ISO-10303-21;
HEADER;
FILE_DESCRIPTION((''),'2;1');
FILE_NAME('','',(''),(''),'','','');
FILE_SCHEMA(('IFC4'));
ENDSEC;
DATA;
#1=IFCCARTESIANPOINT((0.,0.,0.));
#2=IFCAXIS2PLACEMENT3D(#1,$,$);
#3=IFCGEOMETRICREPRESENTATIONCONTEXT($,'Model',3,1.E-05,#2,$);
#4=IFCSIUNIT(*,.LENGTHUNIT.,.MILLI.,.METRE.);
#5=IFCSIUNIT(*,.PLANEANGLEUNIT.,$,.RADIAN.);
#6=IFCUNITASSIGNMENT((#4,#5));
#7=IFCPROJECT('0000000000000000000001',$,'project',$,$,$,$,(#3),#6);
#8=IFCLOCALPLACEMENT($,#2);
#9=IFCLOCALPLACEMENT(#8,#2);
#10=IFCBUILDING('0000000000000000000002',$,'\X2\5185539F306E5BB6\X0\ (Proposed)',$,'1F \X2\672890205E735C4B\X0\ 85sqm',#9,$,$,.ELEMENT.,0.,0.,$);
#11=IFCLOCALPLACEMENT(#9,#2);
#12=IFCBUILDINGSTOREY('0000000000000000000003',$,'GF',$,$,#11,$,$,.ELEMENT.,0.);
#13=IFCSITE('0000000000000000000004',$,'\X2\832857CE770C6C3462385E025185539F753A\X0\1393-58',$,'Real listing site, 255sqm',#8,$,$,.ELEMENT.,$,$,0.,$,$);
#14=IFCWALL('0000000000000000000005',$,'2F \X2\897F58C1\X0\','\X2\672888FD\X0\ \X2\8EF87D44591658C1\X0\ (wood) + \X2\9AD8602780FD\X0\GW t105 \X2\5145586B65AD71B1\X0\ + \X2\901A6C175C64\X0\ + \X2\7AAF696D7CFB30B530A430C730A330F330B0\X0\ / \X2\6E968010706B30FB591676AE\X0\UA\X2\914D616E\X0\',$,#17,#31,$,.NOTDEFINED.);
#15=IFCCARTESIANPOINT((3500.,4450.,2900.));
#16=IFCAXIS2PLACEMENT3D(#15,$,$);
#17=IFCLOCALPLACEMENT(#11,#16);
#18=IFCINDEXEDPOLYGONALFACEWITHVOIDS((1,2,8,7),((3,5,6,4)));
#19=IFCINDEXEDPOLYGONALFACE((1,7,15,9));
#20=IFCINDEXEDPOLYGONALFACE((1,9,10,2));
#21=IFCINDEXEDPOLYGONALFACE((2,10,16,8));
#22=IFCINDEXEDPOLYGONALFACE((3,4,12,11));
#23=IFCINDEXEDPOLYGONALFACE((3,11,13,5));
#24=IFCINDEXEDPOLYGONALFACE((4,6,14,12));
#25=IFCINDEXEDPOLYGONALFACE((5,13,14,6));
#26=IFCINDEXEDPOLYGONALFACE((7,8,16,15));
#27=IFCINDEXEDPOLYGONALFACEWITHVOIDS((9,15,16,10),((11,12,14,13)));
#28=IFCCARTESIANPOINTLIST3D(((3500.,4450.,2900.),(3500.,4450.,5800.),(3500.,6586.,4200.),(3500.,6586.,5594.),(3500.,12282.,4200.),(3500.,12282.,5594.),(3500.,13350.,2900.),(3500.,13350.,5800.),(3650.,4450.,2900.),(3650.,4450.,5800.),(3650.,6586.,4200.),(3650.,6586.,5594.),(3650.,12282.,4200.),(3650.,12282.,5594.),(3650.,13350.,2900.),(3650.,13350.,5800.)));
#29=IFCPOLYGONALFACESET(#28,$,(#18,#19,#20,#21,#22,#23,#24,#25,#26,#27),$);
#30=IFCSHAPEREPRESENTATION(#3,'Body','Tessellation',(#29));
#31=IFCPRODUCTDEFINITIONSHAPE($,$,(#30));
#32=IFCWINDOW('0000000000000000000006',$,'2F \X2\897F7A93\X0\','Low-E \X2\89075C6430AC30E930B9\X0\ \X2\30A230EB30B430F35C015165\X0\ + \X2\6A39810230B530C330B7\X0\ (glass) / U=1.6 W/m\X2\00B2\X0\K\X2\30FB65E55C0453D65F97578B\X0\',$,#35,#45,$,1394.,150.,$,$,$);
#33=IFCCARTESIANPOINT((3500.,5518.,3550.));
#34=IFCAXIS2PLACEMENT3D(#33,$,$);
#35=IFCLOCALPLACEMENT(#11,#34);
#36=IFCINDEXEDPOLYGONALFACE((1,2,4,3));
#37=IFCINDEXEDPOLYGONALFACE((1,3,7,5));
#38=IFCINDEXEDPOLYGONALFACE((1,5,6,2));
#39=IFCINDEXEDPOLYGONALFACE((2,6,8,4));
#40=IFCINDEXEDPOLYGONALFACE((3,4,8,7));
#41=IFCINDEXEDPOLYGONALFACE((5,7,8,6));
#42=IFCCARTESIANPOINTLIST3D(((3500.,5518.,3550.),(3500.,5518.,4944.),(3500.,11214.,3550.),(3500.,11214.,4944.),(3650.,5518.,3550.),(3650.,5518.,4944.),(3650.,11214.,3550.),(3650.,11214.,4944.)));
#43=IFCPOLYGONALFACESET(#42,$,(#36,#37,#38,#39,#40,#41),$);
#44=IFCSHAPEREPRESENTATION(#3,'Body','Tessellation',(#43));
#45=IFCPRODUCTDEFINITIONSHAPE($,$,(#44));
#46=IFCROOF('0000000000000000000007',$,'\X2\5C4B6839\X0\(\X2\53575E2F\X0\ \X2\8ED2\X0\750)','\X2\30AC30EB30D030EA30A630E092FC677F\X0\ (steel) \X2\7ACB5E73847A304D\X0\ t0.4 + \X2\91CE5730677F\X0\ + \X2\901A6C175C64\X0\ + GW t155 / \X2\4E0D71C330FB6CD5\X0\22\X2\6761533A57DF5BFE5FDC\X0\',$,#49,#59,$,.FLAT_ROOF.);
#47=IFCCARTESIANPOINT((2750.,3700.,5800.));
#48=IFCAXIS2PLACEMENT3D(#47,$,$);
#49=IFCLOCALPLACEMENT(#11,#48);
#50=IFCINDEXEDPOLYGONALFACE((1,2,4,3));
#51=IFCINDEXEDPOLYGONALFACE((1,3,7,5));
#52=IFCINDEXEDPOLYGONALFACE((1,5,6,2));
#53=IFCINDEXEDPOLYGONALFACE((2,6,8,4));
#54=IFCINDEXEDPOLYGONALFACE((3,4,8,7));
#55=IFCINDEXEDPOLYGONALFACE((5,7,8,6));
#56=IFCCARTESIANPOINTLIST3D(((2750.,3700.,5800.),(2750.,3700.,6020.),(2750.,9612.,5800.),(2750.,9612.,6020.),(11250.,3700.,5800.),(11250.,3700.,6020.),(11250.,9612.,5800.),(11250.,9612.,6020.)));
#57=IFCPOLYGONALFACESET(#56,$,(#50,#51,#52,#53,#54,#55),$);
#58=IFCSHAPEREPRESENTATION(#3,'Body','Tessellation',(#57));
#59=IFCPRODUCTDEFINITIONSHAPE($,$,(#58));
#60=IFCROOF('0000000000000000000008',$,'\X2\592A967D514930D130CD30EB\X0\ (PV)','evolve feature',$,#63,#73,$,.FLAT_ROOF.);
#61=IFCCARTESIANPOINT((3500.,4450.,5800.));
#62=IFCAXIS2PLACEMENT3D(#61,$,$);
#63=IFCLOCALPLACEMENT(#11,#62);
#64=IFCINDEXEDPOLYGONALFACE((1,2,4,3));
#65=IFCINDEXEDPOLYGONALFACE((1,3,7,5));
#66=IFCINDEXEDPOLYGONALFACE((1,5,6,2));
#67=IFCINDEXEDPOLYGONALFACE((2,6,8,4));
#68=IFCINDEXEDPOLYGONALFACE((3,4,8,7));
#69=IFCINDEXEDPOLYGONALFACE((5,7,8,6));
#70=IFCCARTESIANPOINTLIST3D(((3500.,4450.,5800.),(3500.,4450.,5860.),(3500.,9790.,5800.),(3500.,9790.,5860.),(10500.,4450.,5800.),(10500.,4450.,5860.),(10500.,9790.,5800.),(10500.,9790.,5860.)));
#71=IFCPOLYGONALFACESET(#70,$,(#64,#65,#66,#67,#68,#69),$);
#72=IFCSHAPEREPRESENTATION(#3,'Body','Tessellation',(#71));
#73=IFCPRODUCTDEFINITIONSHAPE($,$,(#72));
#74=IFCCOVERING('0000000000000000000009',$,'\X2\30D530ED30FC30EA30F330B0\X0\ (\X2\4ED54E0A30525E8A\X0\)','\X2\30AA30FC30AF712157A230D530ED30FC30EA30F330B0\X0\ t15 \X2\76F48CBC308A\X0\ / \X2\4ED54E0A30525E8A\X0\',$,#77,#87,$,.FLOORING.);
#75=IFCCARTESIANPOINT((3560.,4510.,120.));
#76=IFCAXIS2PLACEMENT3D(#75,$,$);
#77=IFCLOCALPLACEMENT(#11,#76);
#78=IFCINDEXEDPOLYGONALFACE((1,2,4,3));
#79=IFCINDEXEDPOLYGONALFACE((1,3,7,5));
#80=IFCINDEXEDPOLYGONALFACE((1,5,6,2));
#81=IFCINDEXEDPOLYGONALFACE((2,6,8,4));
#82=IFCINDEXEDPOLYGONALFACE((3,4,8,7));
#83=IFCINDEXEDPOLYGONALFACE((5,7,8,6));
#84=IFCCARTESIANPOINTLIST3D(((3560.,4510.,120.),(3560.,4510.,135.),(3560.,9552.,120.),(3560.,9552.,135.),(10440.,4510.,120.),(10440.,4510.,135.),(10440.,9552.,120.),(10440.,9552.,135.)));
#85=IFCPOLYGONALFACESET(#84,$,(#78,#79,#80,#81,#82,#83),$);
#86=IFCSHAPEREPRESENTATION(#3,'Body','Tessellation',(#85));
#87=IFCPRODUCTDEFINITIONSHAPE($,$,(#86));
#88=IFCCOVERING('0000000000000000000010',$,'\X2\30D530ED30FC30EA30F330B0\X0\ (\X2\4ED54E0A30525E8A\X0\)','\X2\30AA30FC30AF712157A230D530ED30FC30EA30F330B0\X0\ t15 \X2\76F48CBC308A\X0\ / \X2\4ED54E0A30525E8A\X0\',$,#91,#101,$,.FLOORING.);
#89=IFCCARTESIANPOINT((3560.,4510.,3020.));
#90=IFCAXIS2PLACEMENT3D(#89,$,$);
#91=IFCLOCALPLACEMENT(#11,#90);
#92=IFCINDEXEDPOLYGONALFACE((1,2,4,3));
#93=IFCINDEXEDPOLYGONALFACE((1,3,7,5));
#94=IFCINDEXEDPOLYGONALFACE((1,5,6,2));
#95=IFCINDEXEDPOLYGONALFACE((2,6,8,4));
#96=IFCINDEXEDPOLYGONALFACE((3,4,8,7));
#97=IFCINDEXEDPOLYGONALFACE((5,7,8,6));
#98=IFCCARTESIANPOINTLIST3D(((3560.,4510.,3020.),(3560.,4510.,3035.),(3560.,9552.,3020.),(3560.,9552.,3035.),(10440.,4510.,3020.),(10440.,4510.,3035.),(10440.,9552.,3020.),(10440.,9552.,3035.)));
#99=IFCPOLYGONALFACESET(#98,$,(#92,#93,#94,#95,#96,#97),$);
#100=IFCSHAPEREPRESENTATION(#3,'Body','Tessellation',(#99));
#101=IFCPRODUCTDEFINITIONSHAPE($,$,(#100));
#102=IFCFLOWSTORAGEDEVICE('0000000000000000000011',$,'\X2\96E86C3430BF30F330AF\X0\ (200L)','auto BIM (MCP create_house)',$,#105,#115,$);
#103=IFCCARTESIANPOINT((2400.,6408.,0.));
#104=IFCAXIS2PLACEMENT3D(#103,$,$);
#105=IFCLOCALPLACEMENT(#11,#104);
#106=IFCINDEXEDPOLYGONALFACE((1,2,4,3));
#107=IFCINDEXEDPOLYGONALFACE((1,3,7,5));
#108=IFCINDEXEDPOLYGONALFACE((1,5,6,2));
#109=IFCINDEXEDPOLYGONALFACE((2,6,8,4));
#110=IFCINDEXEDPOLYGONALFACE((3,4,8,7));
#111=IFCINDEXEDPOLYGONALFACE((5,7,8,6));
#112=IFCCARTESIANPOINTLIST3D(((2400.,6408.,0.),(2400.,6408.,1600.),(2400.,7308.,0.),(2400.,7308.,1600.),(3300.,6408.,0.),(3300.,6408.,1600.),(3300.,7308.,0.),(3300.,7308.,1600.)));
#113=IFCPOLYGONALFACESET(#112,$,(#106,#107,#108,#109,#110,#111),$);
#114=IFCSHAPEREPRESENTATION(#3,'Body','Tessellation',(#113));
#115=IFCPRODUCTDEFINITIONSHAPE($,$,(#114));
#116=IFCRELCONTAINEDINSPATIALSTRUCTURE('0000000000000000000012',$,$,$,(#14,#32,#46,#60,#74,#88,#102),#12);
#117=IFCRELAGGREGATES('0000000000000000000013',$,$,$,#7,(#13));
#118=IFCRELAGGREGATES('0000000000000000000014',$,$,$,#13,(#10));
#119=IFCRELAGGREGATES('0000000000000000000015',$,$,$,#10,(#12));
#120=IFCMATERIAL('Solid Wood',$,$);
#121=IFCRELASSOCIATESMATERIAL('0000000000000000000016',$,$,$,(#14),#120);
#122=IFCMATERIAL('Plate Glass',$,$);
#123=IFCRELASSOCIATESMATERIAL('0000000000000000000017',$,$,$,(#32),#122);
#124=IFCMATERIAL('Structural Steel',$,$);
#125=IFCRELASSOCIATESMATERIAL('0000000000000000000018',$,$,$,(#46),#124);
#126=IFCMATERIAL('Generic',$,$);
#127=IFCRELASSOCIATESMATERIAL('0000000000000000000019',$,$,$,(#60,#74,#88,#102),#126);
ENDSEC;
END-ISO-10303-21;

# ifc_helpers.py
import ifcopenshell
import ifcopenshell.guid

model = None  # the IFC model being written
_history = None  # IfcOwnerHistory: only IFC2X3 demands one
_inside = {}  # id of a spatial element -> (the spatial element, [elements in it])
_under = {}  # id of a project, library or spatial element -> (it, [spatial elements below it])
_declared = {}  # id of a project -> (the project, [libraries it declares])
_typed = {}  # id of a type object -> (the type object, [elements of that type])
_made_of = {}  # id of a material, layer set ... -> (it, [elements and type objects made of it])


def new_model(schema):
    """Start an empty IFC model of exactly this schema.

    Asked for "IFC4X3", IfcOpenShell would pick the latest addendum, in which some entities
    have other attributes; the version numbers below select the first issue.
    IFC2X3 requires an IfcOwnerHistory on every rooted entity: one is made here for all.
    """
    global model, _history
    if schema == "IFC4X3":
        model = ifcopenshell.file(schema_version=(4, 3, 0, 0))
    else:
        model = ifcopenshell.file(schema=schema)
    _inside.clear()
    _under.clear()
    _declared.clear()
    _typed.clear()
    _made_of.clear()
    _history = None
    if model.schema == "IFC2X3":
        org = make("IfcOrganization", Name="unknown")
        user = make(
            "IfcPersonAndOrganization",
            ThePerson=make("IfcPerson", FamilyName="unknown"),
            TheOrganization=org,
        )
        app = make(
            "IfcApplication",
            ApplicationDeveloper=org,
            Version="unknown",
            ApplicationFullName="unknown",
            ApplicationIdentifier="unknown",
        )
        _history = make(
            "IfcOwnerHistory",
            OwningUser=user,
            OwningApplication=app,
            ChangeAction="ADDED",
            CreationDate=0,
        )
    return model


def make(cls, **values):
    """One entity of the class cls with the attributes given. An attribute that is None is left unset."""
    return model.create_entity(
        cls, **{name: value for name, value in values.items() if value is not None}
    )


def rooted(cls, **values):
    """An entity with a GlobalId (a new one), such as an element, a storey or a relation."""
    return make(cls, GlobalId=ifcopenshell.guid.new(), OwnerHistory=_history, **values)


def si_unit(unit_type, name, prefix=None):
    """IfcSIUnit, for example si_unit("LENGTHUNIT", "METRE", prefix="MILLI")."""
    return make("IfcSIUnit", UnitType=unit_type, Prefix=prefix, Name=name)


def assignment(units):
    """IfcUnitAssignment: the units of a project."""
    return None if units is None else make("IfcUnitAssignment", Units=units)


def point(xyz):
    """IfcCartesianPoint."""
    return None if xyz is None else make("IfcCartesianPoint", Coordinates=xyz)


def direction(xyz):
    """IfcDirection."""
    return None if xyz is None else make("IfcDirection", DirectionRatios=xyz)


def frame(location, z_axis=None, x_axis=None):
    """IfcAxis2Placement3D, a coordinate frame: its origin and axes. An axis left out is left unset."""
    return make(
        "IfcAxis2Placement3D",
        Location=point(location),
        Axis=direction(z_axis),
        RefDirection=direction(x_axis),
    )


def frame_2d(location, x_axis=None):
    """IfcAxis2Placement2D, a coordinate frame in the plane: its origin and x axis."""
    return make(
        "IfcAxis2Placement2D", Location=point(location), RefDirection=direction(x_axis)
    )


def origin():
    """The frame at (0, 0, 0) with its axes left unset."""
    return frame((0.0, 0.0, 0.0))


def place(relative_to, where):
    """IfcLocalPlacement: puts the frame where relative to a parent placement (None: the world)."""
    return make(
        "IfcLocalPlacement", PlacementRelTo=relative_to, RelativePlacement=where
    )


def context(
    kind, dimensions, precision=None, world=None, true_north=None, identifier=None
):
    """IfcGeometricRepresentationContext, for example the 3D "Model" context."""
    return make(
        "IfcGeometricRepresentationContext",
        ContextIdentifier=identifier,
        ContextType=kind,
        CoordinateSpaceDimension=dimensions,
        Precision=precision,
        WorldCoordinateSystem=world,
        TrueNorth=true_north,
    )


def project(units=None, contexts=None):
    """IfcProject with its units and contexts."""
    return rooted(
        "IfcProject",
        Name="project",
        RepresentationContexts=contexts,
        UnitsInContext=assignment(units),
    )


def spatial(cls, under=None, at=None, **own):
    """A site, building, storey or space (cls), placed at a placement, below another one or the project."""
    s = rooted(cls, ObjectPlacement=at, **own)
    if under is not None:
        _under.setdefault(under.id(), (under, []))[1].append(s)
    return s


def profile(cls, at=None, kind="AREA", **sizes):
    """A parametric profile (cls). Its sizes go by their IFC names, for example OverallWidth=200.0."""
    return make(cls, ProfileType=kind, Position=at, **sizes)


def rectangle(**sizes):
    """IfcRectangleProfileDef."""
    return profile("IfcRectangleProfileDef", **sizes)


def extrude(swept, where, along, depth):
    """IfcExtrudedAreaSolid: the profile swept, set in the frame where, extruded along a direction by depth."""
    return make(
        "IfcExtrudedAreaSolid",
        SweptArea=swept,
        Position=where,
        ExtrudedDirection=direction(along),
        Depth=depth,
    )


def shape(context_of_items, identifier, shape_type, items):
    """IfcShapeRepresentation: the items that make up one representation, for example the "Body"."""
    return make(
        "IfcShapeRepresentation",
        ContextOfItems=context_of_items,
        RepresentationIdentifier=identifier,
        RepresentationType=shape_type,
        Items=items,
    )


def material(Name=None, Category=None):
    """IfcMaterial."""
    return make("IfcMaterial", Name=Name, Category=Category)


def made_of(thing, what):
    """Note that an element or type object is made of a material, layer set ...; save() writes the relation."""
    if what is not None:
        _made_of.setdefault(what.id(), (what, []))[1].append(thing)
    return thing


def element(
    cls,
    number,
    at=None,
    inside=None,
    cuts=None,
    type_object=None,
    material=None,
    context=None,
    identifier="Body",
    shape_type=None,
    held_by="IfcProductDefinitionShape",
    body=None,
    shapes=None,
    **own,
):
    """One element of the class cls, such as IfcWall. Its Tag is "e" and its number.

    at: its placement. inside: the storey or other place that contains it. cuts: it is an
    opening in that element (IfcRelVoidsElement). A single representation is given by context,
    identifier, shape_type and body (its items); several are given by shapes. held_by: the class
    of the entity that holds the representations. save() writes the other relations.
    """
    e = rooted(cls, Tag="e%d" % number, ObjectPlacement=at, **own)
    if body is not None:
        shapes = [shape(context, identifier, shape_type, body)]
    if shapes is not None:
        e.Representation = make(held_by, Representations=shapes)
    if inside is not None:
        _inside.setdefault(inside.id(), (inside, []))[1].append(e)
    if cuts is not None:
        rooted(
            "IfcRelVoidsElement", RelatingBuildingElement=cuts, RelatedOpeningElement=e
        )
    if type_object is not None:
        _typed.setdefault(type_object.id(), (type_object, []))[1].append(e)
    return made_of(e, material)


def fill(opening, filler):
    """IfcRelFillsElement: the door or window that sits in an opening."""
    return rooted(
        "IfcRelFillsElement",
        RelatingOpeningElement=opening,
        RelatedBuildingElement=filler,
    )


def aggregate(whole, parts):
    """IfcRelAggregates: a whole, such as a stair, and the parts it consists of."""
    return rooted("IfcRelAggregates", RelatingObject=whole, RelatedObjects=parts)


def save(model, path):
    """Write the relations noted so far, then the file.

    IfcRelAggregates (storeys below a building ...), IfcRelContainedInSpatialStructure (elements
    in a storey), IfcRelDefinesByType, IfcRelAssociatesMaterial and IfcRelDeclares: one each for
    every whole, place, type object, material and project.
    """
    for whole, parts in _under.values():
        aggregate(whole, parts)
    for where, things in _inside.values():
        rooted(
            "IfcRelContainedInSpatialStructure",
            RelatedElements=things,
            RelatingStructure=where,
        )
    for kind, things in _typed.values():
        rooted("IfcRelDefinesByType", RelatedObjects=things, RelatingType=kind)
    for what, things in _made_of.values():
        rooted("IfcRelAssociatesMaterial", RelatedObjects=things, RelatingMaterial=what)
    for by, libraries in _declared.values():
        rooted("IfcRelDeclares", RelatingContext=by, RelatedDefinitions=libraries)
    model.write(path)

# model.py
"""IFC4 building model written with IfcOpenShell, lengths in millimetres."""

from ifc_helpers import new_model, si_unit, frame, frame_2d, origin, place, context, project, spatial, rectangle, extrude, material, element, fill, save


model = new_model("IFC4")

# Units and contexts
model_context = context("Model", 3, precision=1e-05, world=origin())
ifc_project = project(units=[si_unit("LENGTHUNIT", "METRE", prefix="MILLI"), si_unit("PLANEANGLEUNIT", "RADIAN")], contexts=[model_context])

# Site, building, storey
site_placement = place(None, origin())
site = spatial("IfcSite", under=ifc_project, at=site_placement, Name="茨城県水戸市内原町1393-58", ObjectType="Real listing site, 255sqm", CompositionType="ELEMENT", RefElevation=0.0)
building_placement = place(site_placement, origin())
building = spatial("IfcBuilding", under=site, at=building_placement, Name="内原の家 (Proposed)", ObjectType="1F 木造平屋 85sqm", CompositionType="ELEMENT", ElevationOfRefHeight=0.0, ElevationOfTerrain=0.0)
storey_placement = place(building_placement, origin())
storey = spatial("IfcBuildingStorey", under=building, at=storey_placement, Name="GF", CompositionType="ELEMENT", Elevation=0.0)

# Shared definitions
ifc_material_1 = material(Name="Solid Wood")
ifc_material_2 = material(Name="Generic")

# Shared definitions
ifc_material_3 = material(Name="Plate Glass")

# Wall, opening, window
wall_1_placement = place(storey_placement, frame((3500.0, 4450.0, 2900.0)))
wall_1 = element("IfcWall", 1, at=wall_1_placement, inside=storey, material=ifc_material_1, Name="2F 西壁", Description="木製 軸組外壁 (wood) + 高性能GW t105 充填断熱 + 通気層 + 窯業系サイディング / 準耐火・外皮UA配慮", PredefinedType="NOTDEFINED", context=model_context, shape_type="SweptSolid", body=[
    extrude(rectangle(XDim=150.0, YDim=8900.0, at=frame_2d((75.0, 4450.0))), frame((3500.0, 4450.0, 2900.0)), (0.0, 0.0, 1.0), 2900.0),
])
opening_1_placement = place(storey_placement, frame((3500.0, 5518.0, 3550.0)))
opening_1 = element("IfcOpeningElement", 2, at=opening_1_placement, cuts=wall_1, PredefinedType="NOTDEFINED", context=model_context, shape_type="SweptSolid", body=[
    extrude(rectangle(XDim=150.0, YDim=5696.0, at=frame_2d((75.0, 2848.0))), frame((3500.0, 5518.0, 3550.0)), (0.0, 0.0, 1.0), 1394.0),
])
window_1_placement = place(storey_placement, frame((3500.0, 5518.0, 3550.0)))
window_1 = element("IfcWindow", 3, at=window_1_placement, inside=storey, material=ifc_material_3, Name="2F 西窓", Description="Low-E 複層ガラス アルゴン封入 + 樹脂サッシ (glass) / U=1.6 W/m²K・日射取得型", OverallHeight=1394.0, OverallWidth=150.0, context=model_context, shape_type="SweptSolid", body=[
    extrude(rectangle(XDim=150.0, YDim=5696.0, at=frame_2d((75.0, 2848.0))), frame((3500.0, 5518.0, 3550.0)), (0.0, 0.0, 1.0), 1394.0),
])
fill(opening_1, window_1)

# Roofs
ifc_material_4 = material(Name="Structural Steel")
for number, where, name in (
    (4, (2750.0, 3700.0, 5800.0), "屋根(南帯 軒750)"),
):
    element("IfcRoof", number, at=place(storey_placement, frame(where)), inside=storey, material=ifc_material_4, Name=name, Description="ガルバリウム鋼板 (steel) 立平葺き t0.4 + 野地板 + 通気層 + GW t155 / 不燃・法22条区域対応", PredefinedType="FLAT_ROOF", context=model_context, shape_type="SweptSolid", body=[
        extrude(rectangle(XDim=8500.0, YDim=5912.0, at=frame_2d((4250.0, 2956.0))), frame((2750.0, 3700.0, 5800.0)), (0.0, 0.0, 1.0), 220.0),
    ])
roof_placement = place(storey_placement, frame((3500.0, 4450.0, 5800.0)))
element("IfcRoof", 5, at=roof_placement, inside=storey, material=ifc_material_2, Name="太陽光パネル (PV)", Description="evolve feature", PredefinedType="FLAT_ROOF", context=model_context, shape_type="SweptSolid", body=[
    extrude(rectangle(XDim=7000.0, YDim=5340.0, at=frame_2d((3500.0, 2670.0))), frame((3500.0, 4450.0, 5800.0)), (0.0, 0.0, 1.0), 60.0),
])

# Coverings
covering_1_placement = place(storey_placement, frame((3560.0, 4510.0, 120.0)))
element("IfcCovering", 6, at=covering_1_placement, inside=storey, material=ifc_material_2, Name="フローリング (仕上げ床)", Description="オーク無垢フローリング t15 直貼り / 仕上げ床", PredefinedType="FLOORING", context=model_context, shape_type="SweptSolid", body=[
    extrude(rectangle(XDim=6880.0, YDim=5042.0, at=frame_2d((3440.0, 2521.0))), frame((3560.0, 4510.0, 120.0)), (0.0, 0.0, 1.0), 15.0),
])
covering_2_placement = place(storey_placement, frame((3560.0, 4510.0, 3020.0)))
element("IfcCovering", 7, at=covering_2_placement, inside=storey, material=ifc_material_2, Name="フローリング (仕上げ床)", Description="オーク無垢フローリング t15 直貼り / 仕上げ床", PredefinedType="FLOORING", context=model_context, shape_type="SweptSolid", body=[
    extrude(rectangle(XDim=6880.0, YDim=5042.0, at=frame_2d((3440.0, 2521.0))), frame((3560.0, 4510.0, 3020.0)), (0.0, 0.0, 1.0), 15.0),
])

# Flow storage device
flow_storage_device_placement = place(storey_placement, frame((2400.0, 6408.0, 0.0)))
element("IfcFlowStorageDevice", 8, at=flow_storage_device_placement, inside=storey, material=ifc_material_2, Name="雨水タンク (200L)", Description="auto BIM (MCP create_house)", context=model_context, shape_type="SweptSolid", body=[
    extrude(rectangle(XDim=900.0, YDim=900.0, at=frame_2d((450.0, 450.0))), frame((2400.0, 6408.0, 0.0)), (0.0, 0.0, 1.0), 1600.0),
])

save(model, "model.ifc")
